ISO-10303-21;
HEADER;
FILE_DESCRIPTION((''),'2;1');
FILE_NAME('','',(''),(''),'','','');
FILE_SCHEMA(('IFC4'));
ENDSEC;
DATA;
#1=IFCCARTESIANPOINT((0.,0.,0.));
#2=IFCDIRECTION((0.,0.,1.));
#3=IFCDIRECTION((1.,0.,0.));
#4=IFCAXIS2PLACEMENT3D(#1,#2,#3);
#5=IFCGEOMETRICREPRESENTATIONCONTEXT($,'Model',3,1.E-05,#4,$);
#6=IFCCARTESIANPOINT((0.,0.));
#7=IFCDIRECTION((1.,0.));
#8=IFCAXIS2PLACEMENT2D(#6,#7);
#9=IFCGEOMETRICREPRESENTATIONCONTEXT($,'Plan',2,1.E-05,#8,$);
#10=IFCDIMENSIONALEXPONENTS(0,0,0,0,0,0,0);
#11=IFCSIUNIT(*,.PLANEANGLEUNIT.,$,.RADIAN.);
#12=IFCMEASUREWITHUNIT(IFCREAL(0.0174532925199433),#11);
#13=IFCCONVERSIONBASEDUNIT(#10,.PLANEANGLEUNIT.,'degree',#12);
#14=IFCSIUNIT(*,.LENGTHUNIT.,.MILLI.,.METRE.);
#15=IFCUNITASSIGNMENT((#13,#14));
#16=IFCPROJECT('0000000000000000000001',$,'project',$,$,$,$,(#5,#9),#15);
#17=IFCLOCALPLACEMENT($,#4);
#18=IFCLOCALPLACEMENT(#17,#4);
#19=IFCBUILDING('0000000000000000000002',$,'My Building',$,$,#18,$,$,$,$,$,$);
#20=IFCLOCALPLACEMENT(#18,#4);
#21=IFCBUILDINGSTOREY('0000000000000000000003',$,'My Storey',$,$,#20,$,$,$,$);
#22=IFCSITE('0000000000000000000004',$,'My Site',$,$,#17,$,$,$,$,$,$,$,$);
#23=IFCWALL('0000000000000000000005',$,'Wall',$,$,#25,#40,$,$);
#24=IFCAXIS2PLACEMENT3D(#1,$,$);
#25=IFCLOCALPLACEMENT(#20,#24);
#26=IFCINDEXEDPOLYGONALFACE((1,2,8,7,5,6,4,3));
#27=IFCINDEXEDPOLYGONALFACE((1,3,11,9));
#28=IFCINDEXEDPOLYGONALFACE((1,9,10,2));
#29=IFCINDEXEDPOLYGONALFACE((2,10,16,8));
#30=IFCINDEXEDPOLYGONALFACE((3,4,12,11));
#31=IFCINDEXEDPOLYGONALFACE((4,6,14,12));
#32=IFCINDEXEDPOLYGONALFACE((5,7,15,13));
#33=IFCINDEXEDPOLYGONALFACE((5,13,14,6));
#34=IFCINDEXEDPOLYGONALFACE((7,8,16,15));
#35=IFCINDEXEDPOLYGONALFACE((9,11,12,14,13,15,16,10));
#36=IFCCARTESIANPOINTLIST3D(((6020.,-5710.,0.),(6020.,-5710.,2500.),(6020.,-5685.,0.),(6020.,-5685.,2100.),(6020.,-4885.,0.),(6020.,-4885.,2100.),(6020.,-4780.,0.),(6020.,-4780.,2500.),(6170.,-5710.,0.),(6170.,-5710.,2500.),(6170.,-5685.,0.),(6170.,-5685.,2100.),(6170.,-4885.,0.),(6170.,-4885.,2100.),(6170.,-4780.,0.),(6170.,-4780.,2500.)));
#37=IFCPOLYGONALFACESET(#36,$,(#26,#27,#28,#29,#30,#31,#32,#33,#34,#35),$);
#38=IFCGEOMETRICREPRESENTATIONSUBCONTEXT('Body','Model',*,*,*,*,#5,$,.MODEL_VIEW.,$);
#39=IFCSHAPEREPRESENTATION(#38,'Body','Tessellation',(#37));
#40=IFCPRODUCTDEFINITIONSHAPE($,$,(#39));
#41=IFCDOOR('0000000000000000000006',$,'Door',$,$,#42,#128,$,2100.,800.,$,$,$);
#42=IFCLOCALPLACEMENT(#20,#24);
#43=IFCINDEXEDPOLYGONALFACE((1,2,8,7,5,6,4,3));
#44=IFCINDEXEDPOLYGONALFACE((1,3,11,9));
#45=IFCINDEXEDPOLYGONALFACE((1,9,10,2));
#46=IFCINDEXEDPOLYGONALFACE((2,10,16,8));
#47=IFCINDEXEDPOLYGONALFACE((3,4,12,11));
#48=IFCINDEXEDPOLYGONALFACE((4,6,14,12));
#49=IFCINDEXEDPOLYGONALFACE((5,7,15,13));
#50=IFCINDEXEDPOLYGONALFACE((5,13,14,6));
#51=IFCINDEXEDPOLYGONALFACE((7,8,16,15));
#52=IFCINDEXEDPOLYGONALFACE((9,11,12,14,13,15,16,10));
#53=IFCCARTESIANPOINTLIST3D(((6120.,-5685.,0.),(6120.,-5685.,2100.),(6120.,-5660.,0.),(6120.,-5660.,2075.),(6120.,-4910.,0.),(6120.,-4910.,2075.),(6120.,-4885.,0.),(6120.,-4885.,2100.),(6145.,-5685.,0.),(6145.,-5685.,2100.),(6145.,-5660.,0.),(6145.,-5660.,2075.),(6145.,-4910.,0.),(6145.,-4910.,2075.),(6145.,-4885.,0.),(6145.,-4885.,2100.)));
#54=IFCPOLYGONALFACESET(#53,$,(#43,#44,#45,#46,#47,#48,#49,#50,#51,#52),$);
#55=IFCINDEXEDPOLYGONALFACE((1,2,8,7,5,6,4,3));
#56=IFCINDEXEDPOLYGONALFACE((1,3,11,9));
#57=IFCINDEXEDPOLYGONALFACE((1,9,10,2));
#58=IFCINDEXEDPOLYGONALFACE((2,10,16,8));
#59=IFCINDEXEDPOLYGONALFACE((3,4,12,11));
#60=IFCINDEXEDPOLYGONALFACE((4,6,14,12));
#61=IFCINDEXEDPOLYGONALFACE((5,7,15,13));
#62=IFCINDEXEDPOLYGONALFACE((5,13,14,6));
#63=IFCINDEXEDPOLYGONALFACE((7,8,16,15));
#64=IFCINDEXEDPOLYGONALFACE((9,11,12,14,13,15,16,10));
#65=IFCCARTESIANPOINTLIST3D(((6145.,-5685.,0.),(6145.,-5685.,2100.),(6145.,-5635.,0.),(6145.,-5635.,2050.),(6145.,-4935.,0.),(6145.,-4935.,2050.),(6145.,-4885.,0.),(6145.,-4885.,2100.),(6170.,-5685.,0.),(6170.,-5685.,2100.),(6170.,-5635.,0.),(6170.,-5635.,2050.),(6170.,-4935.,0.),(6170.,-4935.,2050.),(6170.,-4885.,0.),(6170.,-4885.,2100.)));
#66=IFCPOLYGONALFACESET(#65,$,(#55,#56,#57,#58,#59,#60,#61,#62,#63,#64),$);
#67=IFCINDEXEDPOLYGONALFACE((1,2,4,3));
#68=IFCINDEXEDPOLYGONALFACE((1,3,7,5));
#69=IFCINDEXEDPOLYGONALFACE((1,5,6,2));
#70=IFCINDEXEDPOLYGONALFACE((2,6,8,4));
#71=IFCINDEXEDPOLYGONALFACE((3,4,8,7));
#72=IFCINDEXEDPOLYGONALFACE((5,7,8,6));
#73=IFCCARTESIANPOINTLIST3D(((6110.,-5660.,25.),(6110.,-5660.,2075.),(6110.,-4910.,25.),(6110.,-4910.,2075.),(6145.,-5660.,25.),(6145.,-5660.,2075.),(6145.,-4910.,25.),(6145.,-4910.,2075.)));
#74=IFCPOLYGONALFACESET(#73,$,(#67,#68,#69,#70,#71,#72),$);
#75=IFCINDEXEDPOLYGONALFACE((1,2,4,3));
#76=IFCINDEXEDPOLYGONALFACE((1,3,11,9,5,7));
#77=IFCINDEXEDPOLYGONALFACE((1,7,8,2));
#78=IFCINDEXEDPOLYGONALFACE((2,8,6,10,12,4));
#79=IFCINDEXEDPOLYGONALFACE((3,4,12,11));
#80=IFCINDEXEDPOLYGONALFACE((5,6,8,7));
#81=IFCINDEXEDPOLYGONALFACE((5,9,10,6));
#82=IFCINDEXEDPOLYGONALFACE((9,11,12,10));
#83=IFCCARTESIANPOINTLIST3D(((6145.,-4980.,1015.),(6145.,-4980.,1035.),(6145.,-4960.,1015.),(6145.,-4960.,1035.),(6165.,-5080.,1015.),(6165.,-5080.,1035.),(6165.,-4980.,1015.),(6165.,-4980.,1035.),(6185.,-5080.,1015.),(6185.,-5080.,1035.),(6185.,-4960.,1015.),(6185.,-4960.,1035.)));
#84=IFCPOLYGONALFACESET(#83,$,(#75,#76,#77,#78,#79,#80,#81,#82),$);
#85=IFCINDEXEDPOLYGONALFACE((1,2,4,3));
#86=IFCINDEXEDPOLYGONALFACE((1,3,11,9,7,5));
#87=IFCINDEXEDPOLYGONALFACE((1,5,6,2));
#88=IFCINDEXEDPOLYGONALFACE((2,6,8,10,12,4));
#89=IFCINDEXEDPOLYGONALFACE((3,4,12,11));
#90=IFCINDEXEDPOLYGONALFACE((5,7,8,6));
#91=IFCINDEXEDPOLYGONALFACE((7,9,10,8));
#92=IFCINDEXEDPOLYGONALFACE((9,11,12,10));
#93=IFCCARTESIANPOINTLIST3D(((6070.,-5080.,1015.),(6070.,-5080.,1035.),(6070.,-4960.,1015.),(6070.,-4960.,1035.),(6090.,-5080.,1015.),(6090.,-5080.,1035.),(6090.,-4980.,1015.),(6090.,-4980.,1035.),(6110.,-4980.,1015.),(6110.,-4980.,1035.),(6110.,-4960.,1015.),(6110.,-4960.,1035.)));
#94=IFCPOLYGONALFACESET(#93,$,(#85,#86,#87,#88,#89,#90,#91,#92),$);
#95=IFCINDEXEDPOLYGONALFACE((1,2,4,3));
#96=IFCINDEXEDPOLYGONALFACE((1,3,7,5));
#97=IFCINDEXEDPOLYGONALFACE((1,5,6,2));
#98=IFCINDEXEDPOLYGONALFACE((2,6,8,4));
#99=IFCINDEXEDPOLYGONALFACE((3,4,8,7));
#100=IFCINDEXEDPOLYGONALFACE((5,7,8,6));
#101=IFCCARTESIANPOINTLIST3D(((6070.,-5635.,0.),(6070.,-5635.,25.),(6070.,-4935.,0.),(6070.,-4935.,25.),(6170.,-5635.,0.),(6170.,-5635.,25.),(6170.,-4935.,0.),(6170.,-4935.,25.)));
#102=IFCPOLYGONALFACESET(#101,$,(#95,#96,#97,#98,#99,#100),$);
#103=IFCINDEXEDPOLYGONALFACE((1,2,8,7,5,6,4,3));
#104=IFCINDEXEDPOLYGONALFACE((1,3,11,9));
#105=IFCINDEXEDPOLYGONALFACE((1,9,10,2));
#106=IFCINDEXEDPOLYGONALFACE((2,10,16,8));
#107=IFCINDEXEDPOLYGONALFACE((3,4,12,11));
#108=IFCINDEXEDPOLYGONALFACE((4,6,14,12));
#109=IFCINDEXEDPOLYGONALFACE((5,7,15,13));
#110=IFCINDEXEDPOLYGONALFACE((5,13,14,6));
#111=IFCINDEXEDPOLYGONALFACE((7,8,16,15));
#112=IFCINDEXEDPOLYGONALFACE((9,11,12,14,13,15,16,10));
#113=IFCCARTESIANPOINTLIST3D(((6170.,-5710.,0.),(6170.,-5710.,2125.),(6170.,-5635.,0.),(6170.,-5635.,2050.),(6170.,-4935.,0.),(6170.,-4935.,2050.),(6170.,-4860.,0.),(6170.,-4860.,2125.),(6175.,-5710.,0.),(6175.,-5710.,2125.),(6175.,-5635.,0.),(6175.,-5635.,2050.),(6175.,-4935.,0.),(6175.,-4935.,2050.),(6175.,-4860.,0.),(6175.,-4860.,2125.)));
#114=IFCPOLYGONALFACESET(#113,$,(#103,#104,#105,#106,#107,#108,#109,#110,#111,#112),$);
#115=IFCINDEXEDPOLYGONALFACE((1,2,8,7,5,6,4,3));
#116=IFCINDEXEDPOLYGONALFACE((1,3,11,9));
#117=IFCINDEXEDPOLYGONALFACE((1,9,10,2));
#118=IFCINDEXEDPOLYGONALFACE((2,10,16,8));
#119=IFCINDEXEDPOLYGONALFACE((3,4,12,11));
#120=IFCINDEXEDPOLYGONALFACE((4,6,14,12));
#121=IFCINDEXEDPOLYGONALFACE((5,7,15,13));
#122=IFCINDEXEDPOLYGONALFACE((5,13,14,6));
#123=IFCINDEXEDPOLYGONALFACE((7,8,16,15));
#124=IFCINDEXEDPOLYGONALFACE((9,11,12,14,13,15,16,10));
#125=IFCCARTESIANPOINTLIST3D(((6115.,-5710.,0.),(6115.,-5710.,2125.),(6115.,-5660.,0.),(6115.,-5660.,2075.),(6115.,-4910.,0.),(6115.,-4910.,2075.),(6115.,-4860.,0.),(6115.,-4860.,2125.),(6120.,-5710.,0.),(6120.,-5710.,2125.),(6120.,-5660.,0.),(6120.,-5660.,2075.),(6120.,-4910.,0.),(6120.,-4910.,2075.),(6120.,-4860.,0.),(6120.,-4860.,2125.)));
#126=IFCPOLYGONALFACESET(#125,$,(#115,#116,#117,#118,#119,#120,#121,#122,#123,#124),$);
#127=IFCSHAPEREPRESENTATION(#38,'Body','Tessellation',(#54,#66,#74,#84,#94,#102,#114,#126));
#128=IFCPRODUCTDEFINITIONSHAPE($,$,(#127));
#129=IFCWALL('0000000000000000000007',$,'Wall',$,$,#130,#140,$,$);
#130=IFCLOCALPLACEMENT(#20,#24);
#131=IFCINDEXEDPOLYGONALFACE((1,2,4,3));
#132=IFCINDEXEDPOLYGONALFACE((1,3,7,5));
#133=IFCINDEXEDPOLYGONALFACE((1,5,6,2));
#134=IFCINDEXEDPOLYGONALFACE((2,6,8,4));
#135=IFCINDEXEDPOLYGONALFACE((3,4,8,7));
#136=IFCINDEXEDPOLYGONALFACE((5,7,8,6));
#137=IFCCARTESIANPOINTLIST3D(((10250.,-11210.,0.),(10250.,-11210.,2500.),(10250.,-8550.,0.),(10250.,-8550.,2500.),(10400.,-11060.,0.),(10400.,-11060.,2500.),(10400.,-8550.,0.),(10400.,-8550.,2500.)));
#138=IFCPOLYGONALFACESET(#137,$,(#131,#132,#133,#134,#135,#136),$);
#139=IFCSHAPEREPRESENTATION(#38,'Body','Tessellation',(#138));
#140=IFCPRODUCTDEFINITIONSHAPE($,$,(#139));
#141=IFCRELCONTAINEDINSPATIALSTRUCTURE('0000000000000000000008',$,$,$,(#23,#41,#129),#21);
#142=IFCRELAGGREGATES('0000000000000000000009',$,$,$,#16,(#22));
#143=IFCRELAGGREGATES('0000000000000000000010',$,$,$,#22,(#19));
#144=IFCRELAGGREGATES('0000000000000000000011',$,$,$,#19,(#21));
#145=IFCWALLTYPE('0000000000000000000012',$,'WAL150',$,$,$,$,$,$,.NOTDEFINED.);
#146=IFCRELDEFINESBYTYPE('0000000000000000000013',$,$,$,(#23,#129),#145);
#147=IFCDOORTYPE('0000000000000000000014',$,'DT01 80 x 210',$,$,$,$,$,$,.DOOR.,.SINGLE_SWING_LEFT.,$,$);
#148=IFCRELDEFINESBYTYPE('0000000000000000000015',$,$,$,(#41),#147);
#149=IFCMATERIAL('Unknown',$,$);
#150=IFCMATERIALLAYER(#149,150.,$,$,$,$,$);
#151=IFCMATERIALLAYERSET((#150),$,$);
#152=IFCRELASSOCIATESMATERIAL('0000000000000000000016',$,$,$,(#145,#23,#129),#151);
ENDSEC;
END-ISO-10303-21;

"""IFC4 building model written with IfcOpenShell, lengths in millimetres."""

from ifc_helpers import new_model, entity, si_unit, converted_unit, frame, origin_with_axes, origin_2d_with_axis, place, context, subcontext, project, spatial, line, indexed_curve, outline, extrude, shape, source, transform, mapped, material, layer, layer_set, layer_usage, type_object, type_shapes, element, fill, save


model = new_model("IFC4")

# Units and contexts
model_context = context("Model", 3, precision=1e-05, world=origin_with_axes())
plan_context = context("Plan", 2, precision=1e-05, world=origin_2d_with_axis())
body_context_1 = subcontext(model_context, "Body", "Model", "MODEL_VIEW")
body_context_2 = subcontext(plan_context, "Body", "Plan", "PLAN_VIEW")
ifc_project = project(units=[converted_unit("PLANEANGLEUNIT", "degree", entity("IfcReal", 0.0174532925199433), si_unit("PLANEANGLEUNIT", "RADIAN"), dimensions=[0, 0, 0, 0, 0, 0, 0]), si_unit("LENGTHUNIT", "METRE", prefix="MILLI")], contexts=[model_context, plan_context])

# Site, building, storey
site_placement = place(None, origin_with_axes())
site = spatial("IfcSite", under=ifc_project, at=site_placement, Name="My Site")
building_placement = place(site_placement, origin_with_axes())
building = spatial("IfcBuilding", under=site, at=building_placement, Name="My Building")
storey_placement = place(building_placement, origin_with_axes())
storey = spatial("IfcBuildingStorey", under=building, at=storey_placement, Name="My Storey")

# Shared definitions
ifc_material = material(Name="Unknown")

# Shared definitions
ifc_layer_1 = layer(ifc_material, 150.0)
ifc_layer_set_1 = layer_set([ifc_layer_1])
wall_type_1 = type_object("IfcWallType", Name="WAL150", PredefinedType="NOTDEFINED", material=ifc_layer_set_1)

# Wall, opening, door
ifc_layer_usage_1 = layer_usage(ifc_layer_set_1, "AXIS2", "POSITIVE", 0.0)
wall_1_placement = place(storey_placement, frame((6170.0, -5710.0, 0.0), z_axis=(0.0, 0.0, 1.0), x_axis=(0.0, 1.0, 0.0)))
wall_1 = element("IfcWall", 1, at=wall_1_placement, inside=storey, type_object=wall_type_1, material=ifc_layer_usage_1, Name="Wall", context=body_context_1, shape_type="SweptSolid", body=[
    extrude(outline(indexed_curve([(0.0, 0.0), (0.0, 150.0), (930.0, 150.0), (930.0, 0.0)], segments=[line(1, 2, 3, 4, 1)])), origin_with_axes(), (0.0, 0.0, 1.0), 2500.0),
])
shared_shape_1 = source(origin_with_axes(), body_context_1, "Body", "SweptSolid", [
    extrude(outline(indexed_curve([(0.0, 0.0), (800.0, 0.0), (800.0, 2100.0), (0.0, 2100.0)], segments=[line(1, 2, 3, 4, 1)])), frame((0.0, -600.0, 0.0), z_axis=(0.0, -1.0, 0.0), x_axis=(1.0, 0.0, 0.0)), (0.0, 0.0, -1.0), 1200.0),
])
opening_1_placement = place(wall_1_placement, frame((25.0, 0.0, 0.0), z_axis=(0.0, 0.0, 1.0), x_axis=(1.0, 0.0, 0.0)))
opening_1 = element("IfcOpeningElement", 2, at=opening_1_placement, cuts=wall_1, PredefinedType="OPENING", context=body_context_1, shape_type="MappedRepresentation", body=[
    mapped(shared_shape_1, transform((0.0, 0.0, 0.0), x_axis=(1.0, 0.0, 0.0), y_axis=(0.0, 1.0, 0.0), z_axis=(0.0, 0.0, 1.0), scale=1.0)),
])
door_type = type_object("IfcDoorType", Name="DT01 80 x 210", OperationType="SINGLE_SWING_LEFT", PredefinedType="DOOR")
shared_shape_2 = source(origin_with_axes(), body_context_1, "Body", "SweptSolid", [
    extrude(outline(indexed_curve([(0.0, 0.0), (0.0, 2100.0), (800.0, 2100.0), (800.0, 0.0), (775.0, 0.0), (775.0, 2075.0), (25.0, 2075.0), (25.0, 0.0)], segments=[line(1, 2, 3, 4, 5, 6, 7, 8, 1)])), frame((0.0, 25.0, 0.0), z_axis=(0.0, -1.0, 0.0), x_axis=(1.0, 0.0, 0.0)), (0.0, 0.0, -1.0), 25.0),
    extrude(outline(indexed_curve([(0.0, 0.0), (0.0, 2100.0), (800.0, 2100.0), (800.0, 0.0), (750.0, 0.0), (750.0, 2050.0), (50.0, 2050.0), (50.0, 0.0)], segments=[line(1, 2, 3, 4, 5, 6, 7, 8, 1)])), frame((0.0, 0.0, 0.0), z_axis=(0.0, -1.0, 0.0), x_axis=(1.0, 0.0, 0.0)), (0.0, 0.0, -1.0), 25.0),
    extrude(outline(indexed_curve([(0.0, 0.0), (750.0, 0.0), (750.0, 35.0), (0.0, 35.0)], segments=[line(1, 2, 3, 4, 1)])), frame((25.0, 25.0, 25.0), z_axis=(0.0, 0.0, 1.0), x_axis=(1.0, 0.0, 0.0)), (0.0, 0.0, 1.0), 2050.0),
    extrude(outline(indexed_curve([(0.0, 0.0), (0.0, -40.0), (-120.0, -40.0), (-120.0, -20.0), (-20.0, -20.0), (-20.0, 0.0)], segments=[line(1, 2, 3, 4, 5, 6, 1)])), frame((725.0, 25.0, 1015.0), z_axis=(0.0, 0.0, 1.0), x_axis=(1.0, 0.0, 0.0)), (0.0, 0.0, 1.0), 20.0),
    extrude(outline(indexed_curve([(0.0, 0.0), (0.0, 40.0), (-120.0, 40.0), (-120.0, 20.0), (-20.0, 20.0), (-20.0, 0.0)], segments=[line(1, 2, 3, 4, 5, 6, 1)])), frame((725.0, 60.0, 1015.0), z_axis=(0.0, 0.0, 1.0), x_axis=(1.0, 0.0, 0.0)), (0.0, 0.0, 1.0), 20.0),
    extrude(outline(indexed_curve([(0.0, 0.0), (700.0, 0.0), (700.0, 100.0), (0.0, 100.0), (0.0, 0.0)])), frame((50.0, 0.0, 0.0), z_axis=(0.0, 0.0, 1.0), x_axis=(1.0, 0.0, 0.0)), (0.0, 0.0, 1.0), 25.0),
    extrude(outline(indexed_curve([(75.0, 0.0), (75.0, 2050.0), (775.0, 2050.0), (775.0, 0.0), (850.0, 0.0), (850.0, 2125.0), (0.0, 2125.0), (0.0, 0.0), (75.0, 0.0)])), frame((-25.0, -5.0, 0.0), z_axis=(0.0, -1.0, 0.0), x_axis=(1.0, 0.0, 0.0)), (0.0, 0.0, -1.0), 5.0),
    extrude(outline(indexed_curve([(50.0, 0.0), (50.0, 2075.0), (800.0, 2075.0), (800.0, 0.0), (850.0, 0.0), (850.0, 2125.0), (0.0, 2125.0), (0.0, 0.0), (50.0, 0.0)])), frame((-25.0, 50.0, 0.0), z_axis=(0.0, -1.0, 0.0), x_axis=(1.0, 0.0, 0.0)), (0.0, 0.0, -1.0), 5.0),
])
shared_shape_3 = source(origin_with_axes(), body_context_2, "Body", "Curve2D", [
    entity("IfcIndexedPolyCurve", entity("IfcCartesianPointList2D", [[0.0, 0.0], [0.0, 50.0], [25.0, 50.0], [25.0, 25.0], [50.0, 25.0], [50.0, 0.0]]), [entity("IfcLineIndex", [1, 2, 3, 4, 5, 6, 1])]),
    entity("IfcIndexedPolyCurve", entity("IfcCartesianPointList2D", [[800.0, 0.0], [800.0, 50.0], [775.0, 50.0], [775.0, 25.0], [750.0, 25.0], [750.0, 0.0]]), [entity("IfcLineIndex", [1, 2, 3, 4, 5, 6, 1])]),
    entity("IfcTrimmedCurve", entity("IfcEllipse", entity("IfcAxis2Placement2D", entity("IfcCartesianPoint", [60.0, 50.0]), entity("IfcDirection", [1.0, 0.0])), 715.0, 750.0), [entity("IfcCartesianPoint", [775.0, 50.0])], [entity("IfcCartesianPoint", [60.0, 800.0])], True, "CARTESIAN"),
    entity("IfcIndexedPolyCurve", entity("IfcCartesianPointList2D", [[25.0, 50.0], [60.0, 50.0], [60.0, 800.0], [25.0, 800.0]]), [entity("IfcLineIndex", [1, 2, 3, 4, 1])]),
])
type_shapes(door_type, [shared_shape_2, shared_shape_3])
door_placement = place(opening_1_placement, frame((0.0, 0.0, 0.0), z_axis=(0.0, 0.0, 1.0), x_axis=(1.0, 0.0, 0.0)))
door = element("IfcDoor", 3, at=door_placement, inside=storey, type_object=door_type, Name="Door", OverallHeight=2100.0, OverallWidth=800.0, shapes=[
    shape(body_context_1, "Body", "MappedRepresentation", [mapped(shared_shape_2, transform((0.0, 0.0, 0.0), x_axis=(1.0, 0.0, 0.0), y_axis=(0.0, 1.0, 0.0), z_axis=(0.0, 0.0, 1.0), scale=1.0))]),
    shape(body_context_2, "Body", "MappedRepresentation", [mapped(shared_shape_3, transform((0.0, 0.0, 0.0), x_axis=(1.0, 0.0, 0.0), y_axis=(0.0, 1.0, 0.0), z_axis=(0.0, 0.0, 1.0), scale=1.0))]),
])
fill(opening_1, door)

# Wall
ifc_layer_usage_2 = layer_usage(ifc_layer_set_1, "AXIS2", "POSITIVE", 0.0)
wall_2_placement = place(storey_placement, frame((10250.0, -8550.0, 0.0), z_axis=(0.0, 0.0, 1.0), x_axis=(0.0, -1.0, 0.0)))
element("IfcWall", 4, at=wall_2_placement, inside=storey, type_object=wall_type_1, material=ifc_layer_usage_2, Name="Wall", context=body_context_1, shape_type="SweptSolid", body=[
    extrude(outline(indexed_curve([(0.0, 0.0), (0.0, 150.0), (2510.0, 150.0), (2660.0, 0.0)], segments=[line(1, 2, 3, 4, 1)])), origin_with_axes(), (0.0, 0.0, 1.0), 2500.0),
])

save(model, "model.ifc")
